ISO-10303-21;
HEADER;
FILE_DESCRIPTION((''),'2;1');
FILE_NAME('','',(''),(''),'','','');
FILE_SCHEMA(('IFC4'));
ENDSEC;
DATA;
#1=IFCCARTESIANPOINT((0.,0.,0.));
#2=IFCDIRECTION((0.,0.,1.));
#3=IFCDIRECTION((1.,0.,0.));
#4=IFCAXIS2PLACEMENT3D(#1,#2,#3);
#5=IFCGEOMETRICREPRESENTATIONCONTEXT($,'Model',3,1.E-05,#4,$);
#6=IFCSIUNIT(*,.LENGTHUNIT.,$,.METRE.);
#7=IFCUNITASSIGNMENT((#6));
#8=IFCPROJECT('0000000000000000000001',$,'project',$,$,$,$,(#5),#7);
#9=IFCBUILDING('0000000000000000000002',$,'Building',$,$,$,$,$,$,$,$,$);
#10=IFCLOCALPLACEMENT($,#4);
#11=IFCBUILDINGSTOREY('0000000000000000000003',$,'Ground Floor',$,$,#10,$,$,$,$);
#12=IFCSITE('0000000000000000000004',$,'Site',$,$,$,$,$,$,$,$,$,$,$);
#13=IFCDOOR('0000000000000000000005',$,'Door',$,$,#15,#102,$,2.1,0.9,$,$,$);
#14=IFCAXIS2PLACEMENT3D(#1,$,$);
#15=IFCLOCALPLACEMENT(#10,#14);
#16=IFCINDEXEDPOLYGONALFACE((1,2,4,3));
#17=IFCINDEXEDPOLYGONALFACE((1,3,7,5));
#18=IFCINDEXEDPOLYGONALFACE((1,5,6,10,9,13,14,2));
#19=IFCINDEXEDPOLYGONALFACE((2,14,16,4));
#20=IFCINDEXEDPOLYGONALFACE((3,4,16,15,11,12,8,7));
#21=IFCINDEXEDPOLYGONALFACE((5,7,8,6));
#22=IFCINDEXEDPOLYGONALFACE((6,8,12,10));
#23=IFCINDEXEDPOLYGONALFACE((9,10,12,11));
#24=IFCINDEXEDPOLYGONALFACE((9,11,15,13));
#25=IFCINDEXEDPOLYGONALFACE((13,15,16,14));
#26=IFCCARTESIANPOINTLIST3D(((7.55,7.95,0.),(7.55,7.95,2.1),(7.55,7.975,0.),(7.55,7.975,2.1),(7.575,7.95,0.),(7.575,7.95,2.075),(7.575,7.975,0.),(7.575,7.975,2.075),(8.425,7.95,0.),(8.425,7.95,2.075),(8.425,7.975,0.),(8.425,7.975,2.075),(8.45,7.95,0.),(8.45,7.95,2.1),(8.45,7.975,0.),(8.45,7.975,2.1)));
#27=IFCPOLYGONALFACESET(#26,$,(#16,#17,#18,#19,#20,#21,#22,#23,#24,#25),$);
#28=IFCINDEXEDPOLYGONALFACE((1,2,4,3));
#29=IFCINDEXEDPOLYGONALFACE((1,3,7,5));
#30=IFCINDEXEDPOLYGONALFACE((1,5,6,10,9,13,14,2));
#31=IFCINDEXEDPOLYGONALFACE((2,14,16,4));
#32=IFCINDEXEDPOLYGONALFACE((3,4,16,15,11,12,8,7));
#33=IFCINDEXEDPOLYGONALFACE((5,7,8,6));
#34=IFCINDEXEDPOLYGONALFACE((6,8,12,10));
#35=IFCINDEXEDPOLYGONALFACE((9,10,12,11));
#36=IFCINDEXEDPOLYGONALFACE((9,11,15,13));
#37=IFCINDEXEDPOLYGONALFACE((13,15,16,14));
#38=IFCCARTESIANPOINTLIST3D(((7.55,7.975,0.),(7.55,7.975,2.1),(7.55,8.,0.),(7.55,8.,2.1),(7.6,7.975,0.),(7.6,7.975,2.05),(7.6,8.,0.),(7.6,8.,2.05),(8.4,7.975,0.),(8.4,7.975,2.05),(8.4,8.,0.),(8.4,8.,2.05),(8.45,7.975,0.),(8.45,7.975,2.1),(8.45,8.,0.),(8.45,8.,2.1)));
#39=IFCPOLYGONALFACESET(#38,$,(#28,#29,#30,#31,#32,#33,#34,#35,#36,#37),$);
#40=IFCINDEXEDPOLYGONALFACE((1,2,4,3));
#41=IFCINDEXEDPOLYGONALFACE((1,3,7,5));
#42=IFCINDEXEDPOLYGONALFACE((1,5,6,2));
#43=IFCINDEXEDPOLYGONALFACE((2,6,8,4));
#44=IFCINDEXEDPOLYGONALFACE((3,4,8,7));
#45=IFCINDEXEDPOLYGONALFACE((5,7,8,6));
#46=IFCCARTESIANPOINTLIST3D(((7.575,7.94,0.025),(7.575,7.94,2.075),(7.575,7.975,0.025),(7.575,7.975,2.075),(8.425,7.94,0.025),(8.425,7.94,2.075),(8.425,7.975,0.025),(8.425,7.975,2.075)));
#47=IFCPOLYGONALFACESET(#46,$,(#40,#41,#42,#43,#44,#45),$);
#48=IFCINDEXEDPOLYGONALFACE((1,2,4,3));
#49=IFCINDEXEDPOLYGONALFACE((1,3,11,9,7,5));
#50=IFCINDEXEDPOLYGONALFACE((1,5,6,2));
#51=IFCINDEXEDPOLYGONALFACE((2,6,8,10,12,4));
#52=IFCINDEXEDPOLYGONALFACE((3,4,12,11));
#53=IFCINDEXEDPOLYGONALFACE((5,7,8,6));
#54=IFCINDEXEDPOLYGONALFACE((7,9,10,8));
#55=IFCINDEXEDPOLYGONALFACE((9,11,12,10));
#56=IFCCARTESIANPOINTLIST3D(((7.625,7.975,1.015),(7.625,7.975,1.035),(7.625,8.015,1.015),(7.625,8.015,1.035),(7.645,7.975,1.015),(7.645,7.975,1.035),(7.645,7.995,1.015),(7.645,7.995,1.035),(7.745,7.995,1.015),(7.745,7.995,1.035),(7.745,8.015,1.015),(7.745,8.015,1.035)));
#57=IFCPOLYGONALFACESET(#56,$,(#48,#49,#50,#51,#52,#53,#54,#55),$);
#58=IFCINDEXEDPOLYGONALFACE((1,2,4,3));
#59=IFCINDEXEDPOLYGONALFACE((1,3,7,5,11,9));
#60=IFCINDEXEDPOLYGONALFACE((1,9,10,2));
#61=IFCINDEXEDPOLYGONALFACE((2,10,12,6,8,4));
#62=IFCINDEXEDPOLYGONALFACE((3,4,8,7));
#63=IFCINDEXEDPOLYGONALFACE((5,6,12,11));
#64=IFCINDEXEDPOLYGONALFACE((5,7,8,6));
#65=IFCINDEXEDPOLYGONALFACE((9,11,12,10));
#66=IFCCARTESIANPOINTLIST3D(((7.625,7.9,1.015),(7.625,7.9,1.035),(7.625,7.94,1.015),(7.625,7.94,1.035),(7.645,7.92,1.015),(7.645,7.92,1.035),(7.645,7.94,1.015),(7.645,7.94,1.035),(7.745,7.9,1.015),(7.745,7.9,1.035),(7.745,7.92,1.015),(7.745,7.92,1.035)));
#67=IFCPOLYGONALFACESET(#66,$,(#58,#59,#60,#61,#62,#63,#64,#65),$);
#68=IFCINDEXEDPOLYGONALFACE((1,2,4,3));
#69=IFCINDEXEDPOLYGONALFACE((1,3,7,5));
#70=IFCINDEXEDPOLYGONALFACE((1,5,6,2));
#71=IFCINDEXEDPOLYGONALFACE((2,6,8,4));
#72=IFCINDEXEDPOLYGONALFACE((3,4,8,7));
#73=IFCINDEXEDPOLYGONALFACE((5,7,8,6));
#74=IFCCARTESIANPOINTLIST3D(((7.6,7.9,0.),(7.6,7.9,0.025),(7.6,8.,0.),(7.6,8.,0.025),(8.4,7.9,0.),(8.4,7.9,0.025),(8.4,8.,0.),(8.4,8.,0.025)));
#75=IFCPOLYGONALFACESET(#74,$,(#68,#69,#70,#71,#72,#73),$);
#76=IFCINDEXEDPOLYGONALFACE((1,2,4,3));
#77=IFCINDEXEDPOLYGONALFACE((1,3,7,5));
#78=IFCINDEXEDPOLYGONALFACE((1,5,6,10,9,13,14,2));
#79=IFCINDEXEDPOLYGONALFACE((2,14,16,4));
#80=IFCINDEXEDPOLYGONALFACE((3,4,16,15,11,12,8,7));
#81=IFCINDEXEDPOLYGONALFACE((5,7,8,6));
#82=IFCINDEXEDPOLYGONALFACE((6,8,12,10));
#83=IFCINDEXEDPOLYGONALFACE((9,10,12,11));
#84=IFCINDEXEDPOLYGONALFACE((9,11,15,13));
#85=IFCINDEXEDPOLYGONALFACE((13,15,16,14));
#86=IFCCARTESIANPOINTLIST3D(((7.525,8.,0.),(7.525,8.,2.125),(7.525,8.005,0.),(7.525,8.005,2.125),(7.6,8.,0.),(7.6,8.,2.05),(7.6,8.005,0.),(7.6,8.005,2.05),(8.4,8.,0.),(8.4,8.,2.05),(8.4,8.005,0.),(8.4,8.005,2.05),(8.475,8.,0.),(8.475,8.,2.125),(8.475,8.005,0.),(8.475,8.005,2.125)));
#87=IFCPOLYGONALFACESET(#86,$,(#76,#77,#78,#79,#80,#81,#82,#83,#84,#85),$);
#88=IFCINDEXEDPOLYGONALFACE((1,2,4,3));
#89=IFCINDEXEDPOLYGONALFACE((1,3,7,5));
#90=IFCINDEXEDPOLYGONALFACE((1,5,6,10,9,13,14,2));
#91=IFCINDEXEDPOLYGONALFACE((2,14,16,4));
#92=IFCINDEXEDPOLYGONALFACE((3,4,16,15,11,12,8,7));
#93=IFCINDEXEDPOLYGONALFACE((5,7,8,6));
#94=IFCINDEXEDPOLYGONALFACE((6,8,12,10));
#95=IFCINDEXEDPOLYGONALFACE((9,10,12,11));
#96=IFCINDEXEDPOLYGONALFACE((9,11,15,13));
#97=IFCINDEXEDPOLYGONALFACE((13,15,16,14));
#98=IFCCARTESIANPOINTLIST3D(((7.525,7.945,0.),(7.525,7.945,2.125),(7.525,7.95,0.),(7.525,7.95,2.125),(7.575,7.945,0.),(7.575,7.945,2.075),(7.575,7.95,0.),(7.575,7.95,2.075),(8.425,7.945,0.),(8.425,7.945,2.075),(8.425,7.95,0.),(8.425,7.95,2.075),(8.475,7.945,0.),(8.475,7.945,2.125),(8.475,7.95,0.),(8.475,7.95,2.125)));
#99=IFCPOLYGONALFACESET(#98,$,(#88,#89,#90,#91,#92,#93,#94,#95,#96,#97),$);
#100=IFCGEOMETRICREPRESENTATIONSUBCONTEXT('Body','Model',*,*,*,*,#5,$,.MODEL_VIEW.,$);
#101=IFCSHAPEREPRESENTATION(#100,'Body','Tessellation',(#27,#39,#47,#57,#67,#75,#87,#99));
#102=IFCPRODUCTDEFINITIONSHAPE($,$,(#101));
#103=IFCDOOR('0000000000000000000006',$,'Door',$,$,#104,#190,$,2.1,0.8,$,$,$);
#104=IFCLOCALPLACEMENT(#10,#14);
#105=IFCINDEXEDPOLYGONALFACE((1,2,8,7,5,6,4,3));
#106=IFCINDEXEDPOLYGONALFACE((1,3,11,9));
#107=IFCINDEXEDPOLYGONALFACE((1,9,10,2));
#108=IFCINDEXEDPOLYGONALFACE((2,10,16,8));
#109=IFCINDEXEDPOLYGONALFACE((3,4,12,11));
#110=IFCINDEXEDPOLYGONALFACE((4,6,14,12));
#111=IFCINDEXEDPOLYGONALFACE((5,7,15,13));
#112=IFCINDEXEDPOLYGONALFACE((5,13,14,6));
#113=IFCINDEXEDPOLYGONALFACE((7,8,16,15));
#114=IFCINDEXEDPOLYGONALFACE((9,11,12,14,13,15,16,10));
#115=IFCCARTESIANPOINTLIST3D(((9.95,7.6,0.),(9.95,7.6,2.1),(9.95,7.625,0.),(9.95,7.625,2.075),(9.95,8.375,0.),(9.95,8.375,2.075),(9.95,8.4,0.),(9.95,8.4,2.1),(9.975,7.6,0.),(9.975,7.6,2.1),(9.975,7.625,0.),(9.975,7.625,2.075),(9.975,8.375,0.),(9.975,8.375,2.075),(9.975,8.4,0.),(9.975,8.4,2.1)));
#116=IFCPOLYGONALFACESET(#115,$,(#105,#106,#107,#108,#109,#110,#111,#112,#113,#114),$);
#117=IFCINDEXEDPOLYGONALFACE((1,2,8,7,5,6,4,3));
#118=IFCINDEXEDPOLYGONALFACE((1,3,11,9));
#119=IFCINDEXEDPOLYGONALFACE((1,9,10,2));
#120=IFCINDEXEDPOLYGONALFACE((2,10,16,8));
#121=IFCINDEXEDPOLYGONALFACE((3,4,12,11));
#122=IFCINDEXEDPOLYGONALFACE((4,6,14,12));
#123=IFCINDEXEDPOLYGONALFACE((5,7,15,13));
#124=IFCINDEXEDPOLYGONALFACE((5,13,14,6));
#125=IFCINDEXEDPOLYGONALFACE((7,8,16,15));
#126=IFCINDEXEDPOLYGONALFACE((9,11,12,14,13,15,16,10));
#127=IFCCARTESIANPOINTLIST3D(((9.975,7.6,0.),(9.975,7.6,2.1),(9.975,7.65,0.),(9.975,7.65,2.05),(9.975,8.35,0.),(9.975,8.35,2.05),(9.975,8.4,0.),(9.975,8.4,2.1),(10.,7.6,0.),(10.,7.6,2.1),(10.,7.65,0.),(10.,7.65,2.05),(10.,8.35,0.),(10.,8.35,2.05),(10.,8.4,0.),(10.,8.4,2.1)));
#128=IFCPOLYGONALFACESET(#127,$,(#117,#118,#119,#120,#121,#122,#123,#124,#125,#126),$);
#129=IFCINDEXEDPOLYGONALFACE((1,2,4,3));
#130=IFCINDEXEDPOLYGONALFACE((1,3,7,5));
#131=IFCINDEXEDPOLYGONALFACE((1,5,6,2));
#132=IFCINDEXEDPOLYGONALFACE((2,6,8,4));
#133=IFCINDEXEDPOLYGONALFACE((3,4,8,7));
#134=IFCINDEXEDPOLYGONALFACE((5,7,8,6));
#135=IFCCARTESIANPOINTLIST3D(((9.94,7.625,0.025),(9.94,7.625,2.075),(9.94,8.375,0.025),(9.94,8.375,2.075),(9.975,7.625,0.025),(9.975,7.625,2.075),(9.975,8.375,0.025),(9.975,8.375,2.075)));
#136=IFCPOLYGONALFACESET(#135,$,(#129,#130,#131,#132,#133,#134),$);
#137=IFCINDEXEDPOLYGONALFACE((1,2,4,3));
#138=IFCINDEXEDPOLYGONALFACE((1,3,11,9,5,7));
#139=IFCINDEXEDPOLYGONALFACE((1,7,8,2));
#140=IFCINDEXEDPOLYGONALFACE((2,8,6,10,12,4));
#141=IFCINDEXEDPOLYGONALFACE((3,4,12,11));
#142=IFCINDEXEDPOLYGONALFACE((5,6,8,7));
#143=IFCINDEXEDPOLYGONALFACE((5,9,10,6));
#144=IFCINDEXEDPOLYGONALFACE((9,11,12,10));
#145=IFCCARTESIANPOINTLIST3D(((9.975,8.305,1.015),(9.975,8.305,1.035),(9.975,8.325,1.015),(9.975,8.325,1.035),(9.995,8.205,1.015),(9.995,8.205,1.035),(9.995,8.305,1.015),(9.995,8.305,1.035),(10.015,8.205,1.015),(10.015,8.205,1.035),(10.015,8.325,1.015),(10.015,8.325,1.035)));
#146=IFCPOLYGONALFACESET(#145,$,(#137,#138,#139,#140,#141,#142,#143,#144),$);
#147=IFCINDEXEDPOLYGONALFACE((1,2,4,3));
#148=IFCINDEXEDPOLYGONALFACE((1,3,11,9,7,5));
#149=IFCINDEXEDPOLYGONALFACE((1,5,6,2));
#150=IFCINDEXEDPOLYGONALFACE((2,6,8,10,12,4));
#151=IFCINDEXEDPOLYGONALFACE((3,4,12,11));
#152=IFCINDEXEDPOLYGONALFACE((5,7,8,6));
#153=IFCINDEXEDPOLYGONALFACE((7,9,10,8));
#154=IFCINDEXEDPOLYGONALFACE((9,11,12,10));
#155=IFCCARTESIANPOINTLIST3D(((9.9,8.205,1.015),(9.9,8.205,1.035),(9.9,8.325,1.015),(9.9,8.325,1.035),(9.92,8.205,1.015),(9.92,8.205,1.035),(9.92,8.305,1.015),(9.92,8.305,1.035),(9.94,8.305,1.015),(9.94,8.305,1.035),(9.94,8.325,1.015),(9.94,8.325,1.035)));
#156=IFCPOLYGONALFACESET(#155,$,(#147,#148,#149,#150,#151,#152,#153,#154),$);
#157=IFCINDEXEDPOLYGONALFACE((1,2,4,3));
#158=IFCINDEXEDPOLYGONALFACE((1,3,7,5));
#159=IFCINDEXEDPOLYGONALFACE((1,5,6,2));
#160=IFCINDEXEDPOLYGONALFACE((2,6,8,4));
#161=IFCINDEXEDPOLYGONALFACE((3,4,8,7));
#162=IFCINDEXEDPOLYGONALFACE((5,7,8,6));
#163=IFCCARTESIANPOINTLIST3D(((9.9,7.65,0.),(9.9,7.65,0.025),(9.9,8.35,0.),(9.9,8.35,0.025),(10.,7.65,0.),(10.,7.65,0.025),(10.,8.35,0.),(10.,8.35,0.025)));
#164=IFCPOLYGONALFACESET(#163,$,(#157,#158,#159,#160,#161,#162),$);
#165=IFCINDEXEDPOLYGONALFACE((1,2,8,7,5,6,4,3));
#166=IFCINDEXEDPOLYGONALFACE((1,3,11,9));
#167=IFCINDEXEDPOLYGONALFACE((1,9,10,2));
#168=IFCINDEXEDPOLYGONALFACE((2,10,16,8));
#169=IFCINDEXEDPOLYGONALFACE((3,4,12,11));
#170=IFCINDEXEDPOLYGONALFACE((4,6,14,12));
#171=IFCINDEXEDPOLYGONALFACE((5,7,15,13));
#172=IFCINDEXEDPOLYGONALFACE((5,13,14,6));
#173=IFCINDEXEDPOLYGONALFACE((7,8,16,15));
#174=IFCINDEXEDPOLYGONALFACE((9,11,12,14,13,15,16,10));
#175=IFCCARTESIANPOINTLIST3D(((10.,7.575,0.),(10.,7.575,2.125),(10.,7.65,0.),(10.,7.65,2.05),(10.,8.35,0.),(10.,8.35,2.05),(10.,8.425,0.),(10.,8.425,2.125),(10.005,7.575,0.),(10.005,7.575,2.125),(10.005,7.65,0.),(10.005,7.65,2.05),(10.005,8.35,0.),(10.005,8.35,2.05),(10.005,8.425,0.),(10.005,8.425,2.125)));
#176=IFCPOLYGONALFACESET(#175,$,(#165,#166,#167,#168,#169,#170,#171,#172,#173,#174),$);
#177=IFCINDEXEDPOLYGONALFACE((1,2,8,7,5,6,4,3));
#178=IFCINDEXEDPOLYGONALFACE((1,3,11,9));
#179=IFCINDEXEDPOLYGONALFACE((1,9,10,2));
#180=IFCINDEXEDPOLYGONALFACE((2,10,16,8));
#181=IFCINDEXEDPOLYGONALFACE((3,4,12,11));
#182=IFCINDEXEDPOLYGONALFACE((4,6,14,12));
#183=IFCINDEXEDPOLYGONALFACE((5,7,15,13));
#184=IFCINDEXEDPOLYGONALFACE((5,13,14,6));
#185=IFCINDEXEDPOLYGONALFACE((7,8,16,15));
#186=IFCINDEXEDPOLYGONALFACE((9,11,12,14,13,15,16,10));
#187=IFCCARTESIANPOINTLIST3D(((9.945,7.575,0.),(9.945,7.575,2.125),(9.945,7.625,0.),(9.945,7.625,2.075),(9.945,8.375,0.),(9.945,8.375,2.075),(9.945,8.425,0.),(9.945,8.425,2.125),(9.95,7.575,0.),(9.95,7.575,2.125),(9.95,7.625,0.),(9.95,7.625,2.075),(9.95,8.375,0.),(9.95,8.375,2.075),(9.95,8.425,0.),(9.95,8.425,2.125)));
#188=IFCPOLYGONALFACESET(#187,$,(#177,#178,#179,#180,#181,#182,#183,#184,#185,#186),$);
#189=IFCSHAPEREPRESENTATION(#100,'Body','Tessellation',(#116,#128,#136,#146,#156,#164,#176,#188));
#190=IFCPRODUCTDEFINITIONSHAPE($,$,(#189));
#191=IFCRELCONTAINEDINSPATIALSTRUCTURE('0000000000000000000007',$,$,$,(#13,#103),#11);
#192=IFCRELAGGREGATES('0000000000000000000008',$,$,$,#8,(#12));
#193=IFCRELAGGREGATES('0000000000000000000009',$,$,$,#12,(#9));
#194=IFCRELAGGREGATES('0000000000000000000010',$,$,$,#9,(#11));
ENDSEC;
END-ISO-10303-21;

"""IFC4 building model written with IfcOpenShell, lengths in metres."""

from ifc_helpers import new_model, si_unit, frame, origin_with_axes, place, context, subcontext, project, spatial, line, indexed_curve, outline, extrude, element, save


model = new_model("IFC4")

# Units and contexts
model_context = context("Model", 3, precision=1e-05, world=origin_with_axes())
body_context = subcontext(model_context, "Body", "Model", "MODEL_VIEW")
ifc_project = project(units=[si_unit("LENGTHUNIT", "METRE")], contexts=[model_context])

# Site, building, storey
site = spatial("IfcSite", under=ifc_project, Name="Site")
building = spatial("IfcBuilding", under=site, Name="Building")
storey_placement = place(None, origin_with_axes())
storey = spatial("IfcBuildingStorey", under=building, at=storey_placement, Name="Ground Floor")

# Doors
door_1_placement = place(storey_placement, frame((8.45, 8.0, 0.0), z_axis=(0.0, 0.0, 1.0), x_axis=(-1.0, 0.0, 0.0)))
element("IfcDoor", 1, at=door_1_placement, inside=storey, Name="Door", OverallHeight=2.1, OverallWidth=0.9, context=body_context, shape_type="SweptSolid", body=[
    extrude(outline(indexed_curve([(0.0, 0.0), (0.0, 2.1), (0.9, 2.1), (0.9, 0.0), (0.875, 0.0), (0.875, 2.075), (0.025, 2.075), (0.025, 0.0)], segments=[line(1, 2, 3, 4, 5, 6, 7, 8, 1)])), frame((0.0, 0.025, 0.0), z_axis=(0.0, -1.0, 0.0), x_axis=(1.0, 0.0, 0.0)), (0.0, 0.0, -1.0), 0.025),
    extrude(outline(indexed_curve([(0.0, 0.0), (0.0, 2.1), (0.9, 2.1), (0.9, 0.0), (0.85, 0.0), (0.85, 2.05), (0.05, 2.05), (0.05, 0.0)], segments=[line(1, 2, 3, 4, 5, 6, 7, 8, 1)])), frame((0.0, 0.0, 0.0), z_axis=(0.0, -1.0, 0.0), x_axis=(1.0, 0.0, 0.0)), (0.0, 0.0, -1.0), 0.025),
    extrude(outline(indexed_curve([(0.0, 0.0), (0.85, 0.0), (0.85, 0.035), (0.0, 0.035)], segments=[line(1, 2, 3, 4, 1)])), frame((0.025, 0.025, 0.025), z_axis=(0.0, 0.0, 1.0), x_axis=(1.0, 0.0, 0.0)), (0.0, 0.0, 1.0), 2.05),
    extrude(outline(indexed_curve([(0.0, 0.0), (0.0, -0.04), (-0.12, -0.04), (-0.12, -0.02), (-0.02, -0.02), (-0.02, 0.0)], segments=[line(1, 2, 3, 4, 5, 6, 1)])), frame((0.825, 0.025, 1.015), z_axis=(0.0, 0.0, 1.0), x_axis=(1.0, 0.0, 0.0)), (0.0, 0.0, 1.0), 0.02),
    extrude(outline(indexed_curve([(0.0, 0.0), (0.0, 0.04), (-0.12, 0.04), (-0.12, 0.02), (-0.02, 0.02), (-0.02, 0.0)], segments=[line(1, 2, 3, 4, 5, 6, 1)])), frame((0.825, 0.06, 1.015), z_axis=(0.0, 0.0, 1.0), x_axis=(1.0, 0.0, 0.0)), (0.0, 0.0, 1.0), 0.02),
    extrude(outline(indexed_curve([(0.0, 0.0), (0.8, 0.0), (0.8, 0.1), (0.0, 0.1)], segments=[line(1, 2, 3, 4, 1)])), frame((0.05, 0.0, 0.0), z_axis=(0.0, 0.0, 1.0), x_axis=(1.0, 0.0, 0.0)), (0.0, 0.0, 1.0), 0.025),
    extrude(outline(indexed_curve([(0.0, 0.0), (0.0, 2.125), (0.95, 2.125), (0.95, 0.0), (0.875, 0.0), (0.875, 2.05), (0.075, 2.05), (0.075, 0.0)], segments=[line(1, 2, 3, 4, 5, 6, 7, 8, 1)])), frame((-0.025, -0.005, 0.0), z_axis=(0.0, -1.0, 0.0), x_axis=(1.0, 0.0, 0.0)), (0.0, 0.0, -1.0), 0.005),
    extrude(outline(indexed_curve([(0.0, 0.0), (0.0, 2.125), (0.95, 2.125), (0.95, 0.0), (0.9, 0.0), (0.9, 2.075), (0.05, 2.075), (0.05, 0.0)], segments=[line(1, 2, 3, 4, 5, 6, 7, 8, 1)])), frame((-0.025, 0.05, 0.0), z_axis=(0.0, -1.0, 0.0), x_axis=(1.0, 0.0, 0.0)), (0.0, 0.0, -1.0), 0.005),
])
door_2_placement = place(storey_placement, frame((10.0, 7.6, 0.0), z_axis=(0.0, 0.0, 1.0), x_axis=(0.0, 1.0, 0.0)))
element("IfcDoor", 2, at=door_2_placement, inside=storey, Name="Door", OverallHeight=2.1, OverallWidth=0.8, context=body_context, shape_type="SweptSolid", body=[
    extrude(outline(indexed_curve([(0.0, 0.0), (0.0, 2.1), (0.8, 2.1), (0.8, 0.0), (0.775, 0.0), (0.775, 2.075), (0.025, 2.075), (0.025, 0.0)], segments=[line(1, 2, 3, 4, 5, 6, 7, 8, 1)])), frame((0.0, 0.025, 0.0), z_axis=(0.0, -1.0, 0.0), x_axis=(1.0, 0.0, 0.0)), (0.0, 0.0, -1.0), 0.025),
    extrude(outline(indexed_curve([(0.0, 0.0), (0.0, 2.1), (0.8, 2.1), (0.8, 0.0), (0.75, 0.0), (0.75, 2.05), (0.05, 2.05), (0.05, 0.0)], segments=[line(1, 2, 3, 4, 5, 6, 7, 8, 1)])), frame((0.0, 0.0, 0.0), z_axis=(0.0, -1.0, 0.0), x_axis=(1.0, 0.0, 0.0)), (0.0, 0.0, -1.0), 0.025),
    extrude(outline(indexed_curve([(0.0, 0.0), (0.75, 0.0), (0.75, 0.035), (0.0, 0.035)], segments=[line(1, 2, 3, 4, 1)])), frame((0.025, 0.025, 0.025), z_axis=(0.0, 0.0, 1.0), x_axis=(1.0, 0.0, 0.0)), (0.0, 0.0, 1.0), 2.05),
    extrude(outline(indexed_curve([(0.0, 0.0), (0.0, -0.04), (-0.12, -0.04), (-0.12, -0.02), (-0.02, -0.02), (-0.02, 0.0)], segments=[line(1, 2, 3, 4, 5, 6, 1)])), frame((0.725, 0.025, 1.015), z_axis=(0.0, 0.0, 1.0), x_axis=(1.0, 0.0, 0.0)), (0.0, 0.0, 1.0), 0.02),
    extrude(outline(indexed_curve([(0.0, 0.0), (0.0, 0.04), (-0.12, 0.04), (-0.12, 0.02), (-0.02, 0.02), (-0.02, 0.0)], segments=[line(1, 2, 3, 4, 5, 6, 1)])), frame((0.725, 0.06, 1.015), z_axis=(0.0, 0.0, 1.0), x_axis=(1.0, 0.0, 0.0)), (0.0, 0.0, 1.0), 0.02),
    extrude(outline(indexed_curve([(0.0, 0.0), (0.7, 0.0), (0.7, 0.1), (0.0, 0.1)], segments=[line(1, 2, 3, 4, 1)])), frame((0.05, 0.0, 0.0), z_axis=(0.0, 0.0, 1.0), x_axis=(1.0, 0.0, 0.0)), (0.0, 0.0, 1.0), 0.025),
    extrude(outline(indexed_curve([(0.0, 0.0), (0.0, 2.125), (0.85, 2.125), (0.85, 0.0), (0.775, 0.0), (0.775, 2.05), (0.075, 2.05), (0.075, 0.0)], segments=[line(1, 2, 3, 4, 5, 6, 7, 8, 1)])), frame((-0.025, -0.005, 0.0), z_axis=(0.0, -1.0, 0.0), x_axis=(1.0, 0.0, 0.0)), (0.0, 0.0, -1.0), 0.005),
    extrude(outline(indexed_curve([(0.0, 0.0), (0.0, 2.125), (0.85, 2.125), (0.85, 0.0), (0.8, 0.0), (0.8, 2.075), (0.05, 2.075), (0.05, 0.0)], segments=[line(1, 2, 3, 4, 5, 6, 7, 8, 1)])), frame((-0.025, 0.05, 0.0), z_axis=(0.0, -1.0, 0.0), x_axis=(1.0, 0.0, 0.0)), (0.0, 0.0, -1.0), 0.005),
])

save(model, "model.ifc")
